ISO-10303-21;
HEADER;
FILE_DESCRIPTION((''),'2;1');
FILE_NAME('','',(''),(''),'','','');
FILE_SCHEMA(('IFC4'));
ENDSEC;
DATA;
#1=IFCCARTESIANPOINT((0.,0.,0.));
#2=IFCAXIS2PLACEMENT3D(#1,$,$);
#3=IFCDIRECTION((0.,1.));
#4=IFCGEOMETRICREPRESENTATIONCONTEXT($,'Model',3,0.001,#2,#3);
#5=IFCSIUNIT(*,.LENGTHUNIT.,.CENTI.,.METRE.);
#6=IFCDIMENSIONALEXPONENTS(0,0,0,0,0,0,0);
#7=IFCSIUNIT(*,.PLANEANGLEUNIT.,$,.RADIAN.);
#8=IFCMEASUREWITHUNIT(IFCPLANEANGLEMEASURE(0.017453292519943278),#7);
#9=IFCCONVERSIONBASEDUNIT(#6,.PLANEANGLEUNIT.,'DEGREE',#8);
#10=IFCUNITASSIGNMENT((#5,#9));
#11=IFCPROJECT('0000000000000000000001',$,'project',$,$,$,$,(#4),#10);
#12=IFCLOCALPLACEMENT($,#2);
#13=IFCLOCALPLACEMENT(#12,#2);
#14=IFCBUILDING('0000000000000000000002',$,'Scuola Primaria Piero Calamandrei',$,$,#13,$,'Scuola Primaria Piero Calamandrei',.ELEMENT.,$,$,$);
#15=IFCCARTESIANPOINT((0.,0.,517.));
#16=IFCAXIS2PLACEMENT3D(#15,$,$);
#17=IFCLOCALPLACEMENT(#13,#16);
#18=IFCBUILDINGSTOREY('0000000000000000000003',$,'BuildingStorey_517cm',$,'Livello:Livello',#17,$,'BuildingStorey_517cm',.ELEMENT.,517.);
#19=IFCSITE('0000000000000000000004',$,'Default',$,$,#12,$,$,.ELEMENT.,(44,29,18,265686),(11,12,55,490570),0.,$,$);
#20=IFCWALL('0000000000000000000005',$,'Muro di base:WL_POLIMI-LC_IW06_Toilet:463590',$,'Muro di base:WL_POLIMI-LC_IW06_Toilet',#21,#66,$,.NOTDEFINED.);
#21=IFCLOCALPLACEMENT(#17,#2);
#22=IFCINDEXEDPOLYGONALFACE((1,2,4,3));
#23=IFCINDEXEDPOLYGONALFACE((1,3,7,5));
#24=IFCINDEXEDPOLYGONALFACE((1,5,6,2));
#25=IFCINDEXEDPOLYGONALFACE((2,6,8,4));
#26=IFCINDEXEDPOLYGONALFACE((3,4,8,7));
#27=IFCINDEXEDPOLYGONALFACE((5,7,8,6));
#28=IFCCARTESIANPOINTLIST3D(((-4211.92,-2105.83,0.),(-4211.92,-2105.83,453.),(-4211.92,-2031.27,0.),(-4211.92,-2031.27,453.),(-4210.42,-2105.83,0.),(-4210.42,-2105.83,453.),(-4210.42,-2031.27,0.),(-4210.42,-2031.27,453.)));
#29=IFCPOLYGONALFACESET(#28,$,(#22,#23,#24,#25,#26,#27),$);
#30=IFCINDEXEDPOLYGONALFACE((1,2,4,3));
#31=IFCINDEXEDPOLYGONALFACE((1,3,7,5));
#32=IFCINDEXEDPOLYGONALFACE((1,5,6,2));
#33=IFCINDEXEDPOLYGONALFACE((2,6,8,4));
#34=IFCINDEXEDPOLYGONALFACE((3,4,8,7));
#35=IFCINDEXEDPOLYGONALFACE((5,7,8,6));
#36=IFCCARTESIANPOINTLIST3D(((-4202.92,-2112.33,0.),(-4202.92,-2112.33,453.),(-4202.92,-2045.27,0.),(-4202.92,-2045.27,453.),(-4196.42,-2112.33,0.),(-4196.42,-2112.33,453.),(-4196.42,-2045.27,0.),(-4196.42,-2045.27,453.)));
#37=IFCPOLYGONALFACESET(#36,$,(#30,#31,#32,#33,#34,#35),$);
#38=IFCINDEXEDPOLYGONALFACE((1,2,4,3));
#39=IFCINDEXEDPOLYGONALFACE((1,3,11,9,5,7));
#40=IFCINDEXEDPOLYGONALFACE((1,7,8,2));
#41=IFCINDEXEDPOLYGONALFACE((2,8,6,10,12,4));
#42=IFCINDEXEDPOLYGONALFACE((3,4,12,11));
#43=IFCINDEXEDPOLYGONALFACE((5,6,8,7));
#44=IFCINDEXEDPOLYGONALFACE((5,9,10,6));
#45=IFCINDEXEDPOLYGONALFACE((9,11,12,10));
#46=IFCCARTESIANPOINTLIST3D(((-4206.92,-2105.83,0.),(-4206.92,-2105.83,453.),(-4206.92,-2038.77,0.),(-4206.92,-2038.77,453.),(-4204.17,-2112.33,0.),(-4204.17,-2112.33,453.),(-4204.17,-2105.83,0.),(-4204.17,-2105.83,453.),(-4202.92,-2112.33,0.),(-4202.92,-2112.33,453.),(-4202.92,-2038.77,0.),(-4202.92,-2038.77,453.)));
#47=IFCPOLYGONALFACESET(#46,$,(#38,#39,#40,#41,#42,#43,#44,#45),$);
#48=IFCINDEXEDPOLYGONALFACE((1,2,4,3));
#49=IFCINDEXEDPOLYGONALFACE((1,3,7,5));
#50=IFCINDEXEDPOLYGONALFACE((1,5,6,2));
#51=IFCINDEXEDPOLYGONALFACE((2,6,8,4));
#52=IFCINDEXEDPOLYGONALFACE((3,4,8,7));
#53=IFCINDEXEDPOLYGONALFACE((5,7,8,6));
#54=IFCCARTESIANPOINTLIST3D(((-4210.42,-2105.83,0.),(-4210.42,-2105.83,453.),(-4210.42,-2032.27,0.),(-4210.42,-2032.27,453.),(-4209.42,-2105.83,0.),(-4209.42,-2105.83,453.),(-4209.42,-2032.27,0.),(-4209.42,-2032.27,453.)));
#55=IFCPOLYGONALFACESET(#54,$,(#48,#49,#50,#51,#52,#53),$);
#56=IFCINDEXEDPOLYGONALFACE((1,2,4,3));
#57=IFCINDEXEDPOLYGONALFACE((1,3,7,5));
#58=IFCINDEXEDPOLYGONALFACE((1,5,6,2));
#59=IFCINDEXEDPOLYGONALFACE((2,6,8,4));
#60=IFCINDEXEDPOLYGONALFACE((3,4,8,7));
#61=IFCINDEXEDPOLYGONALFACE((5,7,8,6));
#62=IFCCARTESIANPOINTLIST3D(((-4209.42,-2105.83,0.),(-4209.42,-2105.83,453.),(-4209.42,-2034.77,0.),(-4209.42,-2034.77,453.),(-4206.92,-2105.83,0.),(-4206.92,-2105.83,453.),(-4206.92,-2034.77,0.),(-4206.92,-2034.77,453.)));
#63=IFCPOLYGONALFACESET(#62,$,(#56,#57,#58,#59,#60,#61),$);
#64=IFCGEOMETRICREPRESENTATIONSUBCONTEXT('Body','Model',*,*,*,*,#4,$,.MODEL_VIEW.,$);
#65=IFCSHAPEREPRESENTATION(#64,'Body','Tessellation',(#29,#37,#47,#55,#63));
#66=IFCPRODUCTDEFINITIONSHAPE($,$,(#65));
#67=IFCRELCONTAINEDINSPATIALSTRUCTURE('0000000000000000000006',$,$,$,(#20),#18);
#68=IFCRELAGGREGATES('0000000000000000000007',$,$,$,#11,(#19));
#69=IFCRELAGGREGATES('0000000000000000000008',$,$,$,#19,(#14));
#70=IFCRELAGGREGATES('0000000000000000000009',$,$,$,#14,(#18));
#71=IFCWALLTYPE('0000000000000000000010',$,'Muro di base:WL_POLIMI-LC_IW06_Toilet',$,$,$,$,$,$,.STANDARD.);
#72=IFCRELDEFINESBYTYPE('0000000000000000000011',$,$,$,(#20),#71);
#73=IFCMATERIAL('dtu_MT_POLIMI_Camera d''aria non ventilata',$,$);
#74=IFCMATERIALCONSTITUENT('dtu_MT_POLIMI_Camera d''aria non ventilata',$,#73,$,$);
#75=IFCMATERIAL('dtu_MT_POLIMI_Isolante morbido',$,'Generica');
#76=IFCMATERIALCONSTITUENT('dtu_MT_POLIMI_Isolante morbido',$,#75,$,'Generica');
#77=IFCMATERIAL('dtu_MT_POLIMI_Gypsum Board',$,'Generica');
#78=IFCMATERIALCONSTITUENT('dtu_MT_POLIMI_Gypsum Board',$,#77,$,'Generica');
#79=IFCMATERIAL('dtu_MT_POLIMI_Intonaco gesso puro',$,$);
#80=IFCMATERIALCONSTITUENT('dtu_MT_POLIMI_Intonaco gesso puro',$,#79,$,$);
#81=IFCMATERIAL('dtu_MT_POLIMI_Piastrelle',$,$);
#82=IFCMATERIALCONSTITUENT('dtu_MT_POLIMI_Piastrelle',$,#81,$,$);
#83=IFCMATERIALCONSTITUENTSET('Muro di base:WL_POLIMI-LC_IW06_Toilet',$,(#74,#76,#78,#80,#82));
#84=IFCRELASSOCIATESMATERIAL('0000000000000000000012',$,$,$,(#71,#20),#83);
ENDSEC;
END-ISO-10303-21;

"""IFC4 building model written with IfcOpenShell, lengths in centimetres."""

from ifc_helpers import new_model, entity, si_unit, converted_unit, direction, frame, origin, place, context, subcontext, project, spatial, indexed_curve, outline, extrude, material, constituent, constituent_set, type_object, element, save


model = new_model("IFC4")

# Units and contexts
model_context = context("Model", 3, precision=0.001, world=origin(), true_north=direction((0.0, 1.0)))
body_context = subcontext(model_context, "Body", "Model", "MODEL_VIEW")
ifc_project = project(units=[si_unit("LENGTHUNIT", "METRE", prefix="CENTI"), converted_unit("PLANEANGLEUNIT", "DEGREE", entity("IfcPlaneAngleMeasure", 0.017453292519943278), si_unit("PLANEANGLEUNIT", "RADIAN"), dimensions=[0, 0, 0, 0, 0, 0, 0])], contexts=[model_context])

# Site, building, storey
site_placement = place(None, origin())
site = spatial("IfcSite", under=ifc_project, at=site_placement, Name="Default", CompositionType="ELEMENT", RefLatitude=(44, 29, 18, 265686), RefLongitude=(11, 12, 55, 490570), RefElevation=0.0)
building_placement = place(site_placement, origin())
building = spatial("IfcBuilding", under=site, at=building_placement, Name="Scuola Primaria Piero Calamandrei", LongName="Scuola Primaria Piero Calamandrei", CompositionType="ELEMENT")
storey_placement = place(building_placement, frame((0.0, 0.0, 517.0)))
storey = spatial("IfcBuildingStorey", under=building, at=storey_placement, Name="BuildingStorey_517cm", ObjectType="Livello:Livello", LongName="BuildingStorey_517cm", CompositionType="ELEMENT", Elevation=517.0)

# Shared definitions
ifc_material_1 = material(Name="dtu_MT_POLIMI_Isolante morbido", Category="Generica")
ifc_material_2 = material(Name="dtu_MT_POLIMI_Gypsum Board", Category="Generica")

# Shared definitions
ifc_material_3 = material(Name="dtu_MT_POLIMI_Camera d'aria non ventilata")
ifc_material_4 = material(Name="dtu_MT_POLIMI_Intonaco gesso puro")

# Wall
ifc_material_5 = material(Name="dtu_MT_POLIMI_Piastrelle")
ifc_constituent_1 = constituent(ifc_material_3, Name="dtu_MT_POLIMI_Camera d'aria non ventilata")
ifc_constituent_2 = constituent(ifc_material_1, Name="dtu_MT_POLIMI_Isolante morbido", Category="Generica")
ifc_constituent_3 = constituent(ifc_material_2, Name="dtu_MT_POLIMI_Gypsum Board", Category="Generica")
ifc_constituent_4 = constituent(ifc_material_4, Name="dtu_MT_POLIMI_Intonaco gesso puro")
ifc_constituent_5 = constituent(ifc_material_5, Name="dtu_MT_POLIMI_Piastrelle")
ifc_constituent_set_1 = constituent_set(constituents=[ifc_constituent_1, ifc_constituent_2, ifc_constituent_3, ifc_constituent_4, ifc_constituent_5], Name="Muro di base:WL_POLIMI-LC_IW06_Toilet")
wall_type_1 = type_object("IfcWallType", Name="Muro di base:WL_POLIMI-LC_IW06_Toilet", PredefinedType="STANDARD", material=ifc_constituent_set_1)
wall_1_placement = place(storey_placement, frame((-4204.17, -2045.27, 0.0), z_axis=(0.0, 0.0, 1.0), x_axis=(0.0, -1.0, 0.0)))
element("IfcWall", 1, at=wall_1_placement, inside=storey, type_object=wall_type_1, material=ifc_constituent_set_1, Name="Muro di base:WL_POLIMI-LC_IW06_Toilet:463590", ObjectType="Muro di base:WL_POLIMI-LC_IW06_Toilet", PredefinedType="NOTDEFINED", context=body_context, shape_type="SweptSolid", body=[
    extrude(outline(indexed_curve([(-0.75, -37.28), (0.75, -37.28), (0.75, 37.28), (-0.75, 37.28), (-0.75, -37.28)], self_intersect=False)), frame((23.28, -7.0, 0.0), z_axis=(0.0, 0.0, 1.0), x_axis=(0.0, 1.0, 0.0)), (0.0, 0.0, 1.0), 453.0),
    extrude(outline(indexed_curve([(-3.25, -33.53), (3.25, -33.53), (3.25, 33.53), (-3.25, 33.53), (-3.25, -33.53)], self_intersect=False)), frame((33.53, 4.5, 0.0), z_axis=(0.0, 0.0, 1.0), x_axis=(0.0, -1.0, 0.0)), (0.0, 0.0, 1.0), 453.0),
    extrude(outline(indexed_curve([(0.5, -26.68), (1.75, -26.68), (1.75, 46.87), (-2.25, 46.87), (-2.25, -20.18), (0.5, -20.18), (0.5, -26.68)], self_intersect=False)), frame((40.37, -0.5, 0.0), z_axis=(0.0, 0.0, 1.0), x_axis=(0.0, 1.0, 0.0)), (0.0, 0.0, 1.0), 453.0),
    extrude(outline(indexed_curve([(-36.78, -0.5), (36.78, -0.5), (36.78, 0.5), (-36.78, 0.5), (-36.78, -0.5)], self_intersect=False)), frame((23.78, -5.75, 0.0)), (0.0, 0.0, 1.0), 453.0),
    extrude(outline(indexed_curve([(-35.53, -1.25), (35.53, -1.25), (35.53, 1.25), (-35.53, 1.25), (-35.53, -1.25)], self_intersect=False)), frame((25.03, -4.0, 0.0)), (0.0, 0.0, 1.0), 453.0),
])

save(model, "model.ifc")
